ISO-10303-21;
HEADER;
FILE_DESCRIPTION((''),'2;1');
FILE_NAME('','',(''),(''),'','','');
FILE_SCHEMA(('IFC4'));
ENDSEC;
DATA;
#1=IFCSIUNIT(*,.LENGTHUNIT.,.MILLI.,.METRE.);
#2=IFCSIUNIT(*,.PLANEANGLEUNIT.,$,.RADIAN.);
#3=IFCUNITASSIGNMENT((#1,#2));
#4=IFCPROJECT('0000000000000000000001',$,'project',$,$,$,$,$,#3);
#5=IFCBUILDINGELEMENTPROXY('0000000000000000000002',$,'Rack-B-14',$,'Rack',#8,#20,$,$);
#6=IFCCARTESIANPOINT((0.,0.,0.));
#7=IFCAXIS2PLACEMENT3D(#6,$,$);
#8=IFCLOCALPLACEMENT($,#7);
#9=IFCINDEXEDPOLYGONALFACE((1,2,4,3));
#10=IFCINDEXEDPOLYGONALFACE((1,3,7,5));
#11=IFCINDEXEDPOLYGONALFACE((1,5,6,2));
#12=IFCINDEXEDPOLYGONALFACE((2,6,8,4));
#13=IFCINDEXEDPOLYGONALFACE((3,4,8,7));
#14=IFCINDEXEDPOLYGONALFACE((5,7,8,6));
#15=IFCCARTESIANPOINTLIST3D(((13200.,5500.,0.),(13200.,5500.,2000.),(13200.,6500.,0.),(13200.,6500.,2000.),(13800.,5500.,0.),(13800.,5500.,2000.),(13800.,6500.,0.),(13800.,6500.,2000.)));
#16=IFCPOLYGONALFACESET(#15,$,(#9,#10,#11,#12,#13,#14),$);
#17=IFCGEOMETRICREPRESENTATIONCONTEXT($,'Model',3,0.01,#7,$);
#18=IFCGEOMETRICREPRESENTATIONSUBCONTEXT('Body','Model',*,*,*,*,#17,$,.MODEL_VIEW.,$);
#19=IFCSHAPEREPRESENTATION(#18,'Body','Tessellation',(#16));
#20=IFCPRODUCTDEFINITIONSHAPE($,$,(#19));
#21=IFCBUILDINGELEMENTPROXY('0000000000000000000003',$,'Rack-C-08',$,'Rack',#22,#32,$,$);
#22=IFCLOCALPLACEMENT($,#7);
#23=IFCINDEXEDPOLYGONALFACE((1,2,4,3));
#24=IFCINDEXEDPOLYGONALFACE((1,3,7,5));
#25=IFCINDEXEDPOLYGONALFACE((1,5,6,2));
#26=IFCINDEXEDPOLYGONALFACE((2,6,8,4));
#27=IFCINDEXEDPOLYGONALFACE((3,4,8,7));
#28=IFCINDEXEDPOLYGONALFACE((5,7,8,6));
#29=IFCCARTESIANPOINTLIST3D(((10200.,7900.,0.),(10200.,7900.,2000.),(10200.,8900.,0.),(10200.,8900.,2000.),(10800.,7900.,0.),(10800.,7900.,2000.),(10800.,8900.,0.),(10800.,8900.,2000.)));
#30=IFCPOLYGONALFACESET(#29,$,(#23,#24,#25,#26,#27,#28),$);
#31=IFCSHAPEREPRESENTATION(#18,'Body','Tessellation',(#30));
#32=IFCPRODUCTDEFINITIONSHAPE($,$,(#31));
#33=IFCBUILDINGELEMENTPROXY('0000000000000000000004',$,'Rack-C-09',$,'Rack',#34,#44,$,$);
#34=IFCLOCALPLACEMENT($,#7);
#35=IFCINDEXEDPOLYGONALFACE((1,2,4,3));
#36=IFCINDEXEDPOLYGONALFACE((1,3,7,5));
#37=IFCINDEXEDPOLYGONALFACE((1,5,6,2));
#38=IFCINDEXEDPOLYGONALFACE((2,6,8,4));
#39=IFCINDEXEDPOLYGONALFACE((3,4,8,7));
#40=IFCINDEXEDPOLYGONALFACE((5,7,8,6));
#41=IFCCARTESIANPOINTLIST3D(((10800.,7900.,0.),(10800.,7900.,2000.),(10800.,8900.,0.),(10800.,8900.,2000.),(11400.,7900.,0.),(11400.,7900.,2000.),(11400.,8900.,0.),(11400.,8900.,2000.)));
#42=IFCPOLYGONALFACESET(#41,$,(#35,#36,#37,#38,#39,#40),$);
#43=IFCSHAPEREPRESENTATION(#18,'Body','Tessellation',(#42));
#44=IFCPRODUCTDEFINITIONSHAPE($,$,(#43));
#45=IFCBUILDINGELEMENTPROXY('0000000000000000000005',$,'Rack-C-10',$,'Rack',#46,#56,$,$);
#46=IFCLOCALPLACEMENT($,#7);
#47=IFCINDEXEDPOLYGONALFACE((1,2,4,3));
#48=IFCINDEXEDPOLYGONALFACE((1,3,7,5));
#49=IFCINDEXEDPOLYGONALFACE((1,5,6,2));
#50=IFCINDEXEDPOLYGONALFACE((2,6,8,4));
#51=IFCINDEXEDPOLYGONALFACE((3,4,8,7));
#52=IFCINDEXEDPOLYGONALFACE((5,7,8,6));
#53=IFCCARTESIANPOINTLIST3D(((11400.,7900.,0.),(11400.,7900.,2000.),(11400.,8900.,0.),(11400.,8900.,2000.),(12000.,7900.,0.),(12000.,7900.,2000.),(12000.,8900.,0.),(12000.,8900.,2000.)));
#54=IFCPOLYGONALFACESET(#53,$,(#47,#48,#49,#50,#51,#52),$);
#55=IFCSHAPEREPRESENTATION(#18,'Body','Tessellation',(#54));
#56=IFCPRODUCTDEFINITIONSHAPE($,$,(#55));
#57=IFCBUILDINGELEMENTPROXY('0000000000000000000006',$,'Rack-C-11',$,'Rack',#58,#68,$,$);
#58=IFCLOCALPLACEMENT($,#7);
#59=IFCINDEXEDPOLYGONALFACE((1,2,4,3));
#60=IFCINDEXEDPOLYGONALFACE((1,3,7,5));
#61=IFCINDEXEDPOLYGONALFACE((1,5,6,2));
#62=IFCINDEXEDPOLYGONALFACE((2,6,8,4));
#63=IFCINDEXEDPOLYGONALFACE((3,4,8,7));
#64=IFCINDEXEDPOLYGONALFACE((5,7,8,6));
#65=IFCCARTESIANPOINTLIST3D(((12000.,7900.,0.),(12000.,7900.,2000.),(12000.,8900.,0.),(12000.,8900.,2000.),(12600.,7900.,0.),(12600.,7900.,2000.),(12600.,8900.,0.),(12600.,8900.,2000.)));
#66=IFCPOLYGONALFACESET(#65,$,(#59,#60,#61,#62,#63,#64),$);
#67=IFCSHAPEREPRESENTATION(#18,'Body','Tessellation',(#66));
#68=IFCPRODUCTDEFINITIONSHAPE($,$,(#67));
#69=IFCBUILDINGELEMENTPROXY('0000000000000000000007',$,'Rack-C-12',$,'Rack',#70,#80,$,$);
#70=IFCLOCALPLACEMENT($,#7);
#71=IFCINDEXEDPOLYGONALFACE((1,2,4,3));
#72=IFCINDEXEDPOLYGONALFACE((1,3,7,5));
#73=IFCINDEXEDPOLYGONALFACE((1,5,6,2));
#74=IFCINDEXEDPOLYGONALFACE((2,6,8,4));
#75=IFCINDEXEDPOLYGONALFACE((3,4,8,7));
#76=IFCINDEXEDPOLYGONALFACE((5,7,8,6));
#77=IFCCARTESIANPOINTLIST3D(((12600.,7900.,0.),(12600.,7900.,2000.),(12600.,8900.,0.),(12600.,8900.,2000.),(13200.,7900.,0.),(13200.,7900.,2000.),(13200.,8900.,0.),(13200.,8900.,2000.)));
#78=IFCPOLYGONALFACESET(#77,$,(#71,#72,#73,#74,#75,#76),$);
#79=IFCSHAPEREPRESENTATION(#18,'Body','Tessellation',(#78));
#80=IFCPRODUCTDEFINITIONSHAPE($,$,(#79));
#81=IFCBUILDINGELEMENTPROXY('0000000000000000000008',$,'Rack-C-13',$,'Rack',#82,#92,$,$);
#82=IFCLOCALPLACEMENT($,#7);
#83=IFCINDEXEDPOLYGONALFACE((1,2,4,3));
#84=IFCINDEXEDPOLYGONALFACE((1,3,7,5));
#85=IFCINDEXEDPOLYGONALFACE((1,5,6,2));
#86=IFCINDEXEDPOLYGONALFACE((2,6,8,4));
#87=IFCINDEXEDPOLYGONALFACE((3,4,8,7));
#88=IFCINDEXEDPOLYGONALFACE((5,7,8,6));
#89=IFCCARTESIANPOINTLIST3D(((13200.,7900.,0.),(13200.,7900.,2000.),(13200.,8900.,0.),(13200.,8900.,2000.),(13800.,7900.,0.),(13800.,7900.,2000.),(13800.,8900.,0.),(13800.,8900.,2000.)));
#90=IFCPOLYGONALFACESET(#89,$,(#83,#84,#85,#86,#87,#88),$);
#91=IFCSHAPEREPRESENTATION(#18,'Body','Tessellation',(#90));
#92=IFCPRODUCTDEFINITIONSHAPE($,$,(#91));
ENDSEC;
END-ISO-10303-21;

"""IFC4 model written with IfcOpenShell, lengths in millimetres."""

from ifc_helpers import new_model, si_unit, frame, origin, place, context, subcontext, project, rectangle, extrude, element, save


model = new_model("IFC4")

# Units and contexts
model_context = context("Model", 3, precision=0.01, world=origin())
body_context = subcontext(model_context, "Body", "Model", "MODEL_VIEW")
ifc_project = project(units=[si_unit("LENGTHUNIT", "METRE", prefix="MILLI"), si_unit("PLANEANGLEUNIT", "RADIAN")])

# Shared definitions
placement = place(None, origin())

# Building element proxies
for number, where, name in (
    (1, (13500.0, 6000.0, 0.0), "Rack-B-14"),
    (2, (10500.0, 8400.0, 0.0), "Rack-C-08"),
    (3, (11100.0, 8400.0, 0.0), "Rack-C-09"),
    (4, (11700.0, 8400.0, 0.0), "Rack-C-10"),
    (5, (12300.0, 8400.0, 0.0), "Rack-C-11"),
    (6, (12900.0, 8400.0, 0.0), "Rack-C-12"),
    (7, (13500.0, 8400.0, 0.0), "Rack-C-13"),
):
    element("IfcBuildingElementProxy", number, at=place(placement, frame(where)), Name=name, ObjectType="Rack", context=body_context, shape_type="SweptSolid", body=[
        extrude(rectangle(XDim=600.0, YDim=1000.0), origin(), (0.0, 0.0, 1.0), 2000.0),
    ])

save(model, "model.ifc")
